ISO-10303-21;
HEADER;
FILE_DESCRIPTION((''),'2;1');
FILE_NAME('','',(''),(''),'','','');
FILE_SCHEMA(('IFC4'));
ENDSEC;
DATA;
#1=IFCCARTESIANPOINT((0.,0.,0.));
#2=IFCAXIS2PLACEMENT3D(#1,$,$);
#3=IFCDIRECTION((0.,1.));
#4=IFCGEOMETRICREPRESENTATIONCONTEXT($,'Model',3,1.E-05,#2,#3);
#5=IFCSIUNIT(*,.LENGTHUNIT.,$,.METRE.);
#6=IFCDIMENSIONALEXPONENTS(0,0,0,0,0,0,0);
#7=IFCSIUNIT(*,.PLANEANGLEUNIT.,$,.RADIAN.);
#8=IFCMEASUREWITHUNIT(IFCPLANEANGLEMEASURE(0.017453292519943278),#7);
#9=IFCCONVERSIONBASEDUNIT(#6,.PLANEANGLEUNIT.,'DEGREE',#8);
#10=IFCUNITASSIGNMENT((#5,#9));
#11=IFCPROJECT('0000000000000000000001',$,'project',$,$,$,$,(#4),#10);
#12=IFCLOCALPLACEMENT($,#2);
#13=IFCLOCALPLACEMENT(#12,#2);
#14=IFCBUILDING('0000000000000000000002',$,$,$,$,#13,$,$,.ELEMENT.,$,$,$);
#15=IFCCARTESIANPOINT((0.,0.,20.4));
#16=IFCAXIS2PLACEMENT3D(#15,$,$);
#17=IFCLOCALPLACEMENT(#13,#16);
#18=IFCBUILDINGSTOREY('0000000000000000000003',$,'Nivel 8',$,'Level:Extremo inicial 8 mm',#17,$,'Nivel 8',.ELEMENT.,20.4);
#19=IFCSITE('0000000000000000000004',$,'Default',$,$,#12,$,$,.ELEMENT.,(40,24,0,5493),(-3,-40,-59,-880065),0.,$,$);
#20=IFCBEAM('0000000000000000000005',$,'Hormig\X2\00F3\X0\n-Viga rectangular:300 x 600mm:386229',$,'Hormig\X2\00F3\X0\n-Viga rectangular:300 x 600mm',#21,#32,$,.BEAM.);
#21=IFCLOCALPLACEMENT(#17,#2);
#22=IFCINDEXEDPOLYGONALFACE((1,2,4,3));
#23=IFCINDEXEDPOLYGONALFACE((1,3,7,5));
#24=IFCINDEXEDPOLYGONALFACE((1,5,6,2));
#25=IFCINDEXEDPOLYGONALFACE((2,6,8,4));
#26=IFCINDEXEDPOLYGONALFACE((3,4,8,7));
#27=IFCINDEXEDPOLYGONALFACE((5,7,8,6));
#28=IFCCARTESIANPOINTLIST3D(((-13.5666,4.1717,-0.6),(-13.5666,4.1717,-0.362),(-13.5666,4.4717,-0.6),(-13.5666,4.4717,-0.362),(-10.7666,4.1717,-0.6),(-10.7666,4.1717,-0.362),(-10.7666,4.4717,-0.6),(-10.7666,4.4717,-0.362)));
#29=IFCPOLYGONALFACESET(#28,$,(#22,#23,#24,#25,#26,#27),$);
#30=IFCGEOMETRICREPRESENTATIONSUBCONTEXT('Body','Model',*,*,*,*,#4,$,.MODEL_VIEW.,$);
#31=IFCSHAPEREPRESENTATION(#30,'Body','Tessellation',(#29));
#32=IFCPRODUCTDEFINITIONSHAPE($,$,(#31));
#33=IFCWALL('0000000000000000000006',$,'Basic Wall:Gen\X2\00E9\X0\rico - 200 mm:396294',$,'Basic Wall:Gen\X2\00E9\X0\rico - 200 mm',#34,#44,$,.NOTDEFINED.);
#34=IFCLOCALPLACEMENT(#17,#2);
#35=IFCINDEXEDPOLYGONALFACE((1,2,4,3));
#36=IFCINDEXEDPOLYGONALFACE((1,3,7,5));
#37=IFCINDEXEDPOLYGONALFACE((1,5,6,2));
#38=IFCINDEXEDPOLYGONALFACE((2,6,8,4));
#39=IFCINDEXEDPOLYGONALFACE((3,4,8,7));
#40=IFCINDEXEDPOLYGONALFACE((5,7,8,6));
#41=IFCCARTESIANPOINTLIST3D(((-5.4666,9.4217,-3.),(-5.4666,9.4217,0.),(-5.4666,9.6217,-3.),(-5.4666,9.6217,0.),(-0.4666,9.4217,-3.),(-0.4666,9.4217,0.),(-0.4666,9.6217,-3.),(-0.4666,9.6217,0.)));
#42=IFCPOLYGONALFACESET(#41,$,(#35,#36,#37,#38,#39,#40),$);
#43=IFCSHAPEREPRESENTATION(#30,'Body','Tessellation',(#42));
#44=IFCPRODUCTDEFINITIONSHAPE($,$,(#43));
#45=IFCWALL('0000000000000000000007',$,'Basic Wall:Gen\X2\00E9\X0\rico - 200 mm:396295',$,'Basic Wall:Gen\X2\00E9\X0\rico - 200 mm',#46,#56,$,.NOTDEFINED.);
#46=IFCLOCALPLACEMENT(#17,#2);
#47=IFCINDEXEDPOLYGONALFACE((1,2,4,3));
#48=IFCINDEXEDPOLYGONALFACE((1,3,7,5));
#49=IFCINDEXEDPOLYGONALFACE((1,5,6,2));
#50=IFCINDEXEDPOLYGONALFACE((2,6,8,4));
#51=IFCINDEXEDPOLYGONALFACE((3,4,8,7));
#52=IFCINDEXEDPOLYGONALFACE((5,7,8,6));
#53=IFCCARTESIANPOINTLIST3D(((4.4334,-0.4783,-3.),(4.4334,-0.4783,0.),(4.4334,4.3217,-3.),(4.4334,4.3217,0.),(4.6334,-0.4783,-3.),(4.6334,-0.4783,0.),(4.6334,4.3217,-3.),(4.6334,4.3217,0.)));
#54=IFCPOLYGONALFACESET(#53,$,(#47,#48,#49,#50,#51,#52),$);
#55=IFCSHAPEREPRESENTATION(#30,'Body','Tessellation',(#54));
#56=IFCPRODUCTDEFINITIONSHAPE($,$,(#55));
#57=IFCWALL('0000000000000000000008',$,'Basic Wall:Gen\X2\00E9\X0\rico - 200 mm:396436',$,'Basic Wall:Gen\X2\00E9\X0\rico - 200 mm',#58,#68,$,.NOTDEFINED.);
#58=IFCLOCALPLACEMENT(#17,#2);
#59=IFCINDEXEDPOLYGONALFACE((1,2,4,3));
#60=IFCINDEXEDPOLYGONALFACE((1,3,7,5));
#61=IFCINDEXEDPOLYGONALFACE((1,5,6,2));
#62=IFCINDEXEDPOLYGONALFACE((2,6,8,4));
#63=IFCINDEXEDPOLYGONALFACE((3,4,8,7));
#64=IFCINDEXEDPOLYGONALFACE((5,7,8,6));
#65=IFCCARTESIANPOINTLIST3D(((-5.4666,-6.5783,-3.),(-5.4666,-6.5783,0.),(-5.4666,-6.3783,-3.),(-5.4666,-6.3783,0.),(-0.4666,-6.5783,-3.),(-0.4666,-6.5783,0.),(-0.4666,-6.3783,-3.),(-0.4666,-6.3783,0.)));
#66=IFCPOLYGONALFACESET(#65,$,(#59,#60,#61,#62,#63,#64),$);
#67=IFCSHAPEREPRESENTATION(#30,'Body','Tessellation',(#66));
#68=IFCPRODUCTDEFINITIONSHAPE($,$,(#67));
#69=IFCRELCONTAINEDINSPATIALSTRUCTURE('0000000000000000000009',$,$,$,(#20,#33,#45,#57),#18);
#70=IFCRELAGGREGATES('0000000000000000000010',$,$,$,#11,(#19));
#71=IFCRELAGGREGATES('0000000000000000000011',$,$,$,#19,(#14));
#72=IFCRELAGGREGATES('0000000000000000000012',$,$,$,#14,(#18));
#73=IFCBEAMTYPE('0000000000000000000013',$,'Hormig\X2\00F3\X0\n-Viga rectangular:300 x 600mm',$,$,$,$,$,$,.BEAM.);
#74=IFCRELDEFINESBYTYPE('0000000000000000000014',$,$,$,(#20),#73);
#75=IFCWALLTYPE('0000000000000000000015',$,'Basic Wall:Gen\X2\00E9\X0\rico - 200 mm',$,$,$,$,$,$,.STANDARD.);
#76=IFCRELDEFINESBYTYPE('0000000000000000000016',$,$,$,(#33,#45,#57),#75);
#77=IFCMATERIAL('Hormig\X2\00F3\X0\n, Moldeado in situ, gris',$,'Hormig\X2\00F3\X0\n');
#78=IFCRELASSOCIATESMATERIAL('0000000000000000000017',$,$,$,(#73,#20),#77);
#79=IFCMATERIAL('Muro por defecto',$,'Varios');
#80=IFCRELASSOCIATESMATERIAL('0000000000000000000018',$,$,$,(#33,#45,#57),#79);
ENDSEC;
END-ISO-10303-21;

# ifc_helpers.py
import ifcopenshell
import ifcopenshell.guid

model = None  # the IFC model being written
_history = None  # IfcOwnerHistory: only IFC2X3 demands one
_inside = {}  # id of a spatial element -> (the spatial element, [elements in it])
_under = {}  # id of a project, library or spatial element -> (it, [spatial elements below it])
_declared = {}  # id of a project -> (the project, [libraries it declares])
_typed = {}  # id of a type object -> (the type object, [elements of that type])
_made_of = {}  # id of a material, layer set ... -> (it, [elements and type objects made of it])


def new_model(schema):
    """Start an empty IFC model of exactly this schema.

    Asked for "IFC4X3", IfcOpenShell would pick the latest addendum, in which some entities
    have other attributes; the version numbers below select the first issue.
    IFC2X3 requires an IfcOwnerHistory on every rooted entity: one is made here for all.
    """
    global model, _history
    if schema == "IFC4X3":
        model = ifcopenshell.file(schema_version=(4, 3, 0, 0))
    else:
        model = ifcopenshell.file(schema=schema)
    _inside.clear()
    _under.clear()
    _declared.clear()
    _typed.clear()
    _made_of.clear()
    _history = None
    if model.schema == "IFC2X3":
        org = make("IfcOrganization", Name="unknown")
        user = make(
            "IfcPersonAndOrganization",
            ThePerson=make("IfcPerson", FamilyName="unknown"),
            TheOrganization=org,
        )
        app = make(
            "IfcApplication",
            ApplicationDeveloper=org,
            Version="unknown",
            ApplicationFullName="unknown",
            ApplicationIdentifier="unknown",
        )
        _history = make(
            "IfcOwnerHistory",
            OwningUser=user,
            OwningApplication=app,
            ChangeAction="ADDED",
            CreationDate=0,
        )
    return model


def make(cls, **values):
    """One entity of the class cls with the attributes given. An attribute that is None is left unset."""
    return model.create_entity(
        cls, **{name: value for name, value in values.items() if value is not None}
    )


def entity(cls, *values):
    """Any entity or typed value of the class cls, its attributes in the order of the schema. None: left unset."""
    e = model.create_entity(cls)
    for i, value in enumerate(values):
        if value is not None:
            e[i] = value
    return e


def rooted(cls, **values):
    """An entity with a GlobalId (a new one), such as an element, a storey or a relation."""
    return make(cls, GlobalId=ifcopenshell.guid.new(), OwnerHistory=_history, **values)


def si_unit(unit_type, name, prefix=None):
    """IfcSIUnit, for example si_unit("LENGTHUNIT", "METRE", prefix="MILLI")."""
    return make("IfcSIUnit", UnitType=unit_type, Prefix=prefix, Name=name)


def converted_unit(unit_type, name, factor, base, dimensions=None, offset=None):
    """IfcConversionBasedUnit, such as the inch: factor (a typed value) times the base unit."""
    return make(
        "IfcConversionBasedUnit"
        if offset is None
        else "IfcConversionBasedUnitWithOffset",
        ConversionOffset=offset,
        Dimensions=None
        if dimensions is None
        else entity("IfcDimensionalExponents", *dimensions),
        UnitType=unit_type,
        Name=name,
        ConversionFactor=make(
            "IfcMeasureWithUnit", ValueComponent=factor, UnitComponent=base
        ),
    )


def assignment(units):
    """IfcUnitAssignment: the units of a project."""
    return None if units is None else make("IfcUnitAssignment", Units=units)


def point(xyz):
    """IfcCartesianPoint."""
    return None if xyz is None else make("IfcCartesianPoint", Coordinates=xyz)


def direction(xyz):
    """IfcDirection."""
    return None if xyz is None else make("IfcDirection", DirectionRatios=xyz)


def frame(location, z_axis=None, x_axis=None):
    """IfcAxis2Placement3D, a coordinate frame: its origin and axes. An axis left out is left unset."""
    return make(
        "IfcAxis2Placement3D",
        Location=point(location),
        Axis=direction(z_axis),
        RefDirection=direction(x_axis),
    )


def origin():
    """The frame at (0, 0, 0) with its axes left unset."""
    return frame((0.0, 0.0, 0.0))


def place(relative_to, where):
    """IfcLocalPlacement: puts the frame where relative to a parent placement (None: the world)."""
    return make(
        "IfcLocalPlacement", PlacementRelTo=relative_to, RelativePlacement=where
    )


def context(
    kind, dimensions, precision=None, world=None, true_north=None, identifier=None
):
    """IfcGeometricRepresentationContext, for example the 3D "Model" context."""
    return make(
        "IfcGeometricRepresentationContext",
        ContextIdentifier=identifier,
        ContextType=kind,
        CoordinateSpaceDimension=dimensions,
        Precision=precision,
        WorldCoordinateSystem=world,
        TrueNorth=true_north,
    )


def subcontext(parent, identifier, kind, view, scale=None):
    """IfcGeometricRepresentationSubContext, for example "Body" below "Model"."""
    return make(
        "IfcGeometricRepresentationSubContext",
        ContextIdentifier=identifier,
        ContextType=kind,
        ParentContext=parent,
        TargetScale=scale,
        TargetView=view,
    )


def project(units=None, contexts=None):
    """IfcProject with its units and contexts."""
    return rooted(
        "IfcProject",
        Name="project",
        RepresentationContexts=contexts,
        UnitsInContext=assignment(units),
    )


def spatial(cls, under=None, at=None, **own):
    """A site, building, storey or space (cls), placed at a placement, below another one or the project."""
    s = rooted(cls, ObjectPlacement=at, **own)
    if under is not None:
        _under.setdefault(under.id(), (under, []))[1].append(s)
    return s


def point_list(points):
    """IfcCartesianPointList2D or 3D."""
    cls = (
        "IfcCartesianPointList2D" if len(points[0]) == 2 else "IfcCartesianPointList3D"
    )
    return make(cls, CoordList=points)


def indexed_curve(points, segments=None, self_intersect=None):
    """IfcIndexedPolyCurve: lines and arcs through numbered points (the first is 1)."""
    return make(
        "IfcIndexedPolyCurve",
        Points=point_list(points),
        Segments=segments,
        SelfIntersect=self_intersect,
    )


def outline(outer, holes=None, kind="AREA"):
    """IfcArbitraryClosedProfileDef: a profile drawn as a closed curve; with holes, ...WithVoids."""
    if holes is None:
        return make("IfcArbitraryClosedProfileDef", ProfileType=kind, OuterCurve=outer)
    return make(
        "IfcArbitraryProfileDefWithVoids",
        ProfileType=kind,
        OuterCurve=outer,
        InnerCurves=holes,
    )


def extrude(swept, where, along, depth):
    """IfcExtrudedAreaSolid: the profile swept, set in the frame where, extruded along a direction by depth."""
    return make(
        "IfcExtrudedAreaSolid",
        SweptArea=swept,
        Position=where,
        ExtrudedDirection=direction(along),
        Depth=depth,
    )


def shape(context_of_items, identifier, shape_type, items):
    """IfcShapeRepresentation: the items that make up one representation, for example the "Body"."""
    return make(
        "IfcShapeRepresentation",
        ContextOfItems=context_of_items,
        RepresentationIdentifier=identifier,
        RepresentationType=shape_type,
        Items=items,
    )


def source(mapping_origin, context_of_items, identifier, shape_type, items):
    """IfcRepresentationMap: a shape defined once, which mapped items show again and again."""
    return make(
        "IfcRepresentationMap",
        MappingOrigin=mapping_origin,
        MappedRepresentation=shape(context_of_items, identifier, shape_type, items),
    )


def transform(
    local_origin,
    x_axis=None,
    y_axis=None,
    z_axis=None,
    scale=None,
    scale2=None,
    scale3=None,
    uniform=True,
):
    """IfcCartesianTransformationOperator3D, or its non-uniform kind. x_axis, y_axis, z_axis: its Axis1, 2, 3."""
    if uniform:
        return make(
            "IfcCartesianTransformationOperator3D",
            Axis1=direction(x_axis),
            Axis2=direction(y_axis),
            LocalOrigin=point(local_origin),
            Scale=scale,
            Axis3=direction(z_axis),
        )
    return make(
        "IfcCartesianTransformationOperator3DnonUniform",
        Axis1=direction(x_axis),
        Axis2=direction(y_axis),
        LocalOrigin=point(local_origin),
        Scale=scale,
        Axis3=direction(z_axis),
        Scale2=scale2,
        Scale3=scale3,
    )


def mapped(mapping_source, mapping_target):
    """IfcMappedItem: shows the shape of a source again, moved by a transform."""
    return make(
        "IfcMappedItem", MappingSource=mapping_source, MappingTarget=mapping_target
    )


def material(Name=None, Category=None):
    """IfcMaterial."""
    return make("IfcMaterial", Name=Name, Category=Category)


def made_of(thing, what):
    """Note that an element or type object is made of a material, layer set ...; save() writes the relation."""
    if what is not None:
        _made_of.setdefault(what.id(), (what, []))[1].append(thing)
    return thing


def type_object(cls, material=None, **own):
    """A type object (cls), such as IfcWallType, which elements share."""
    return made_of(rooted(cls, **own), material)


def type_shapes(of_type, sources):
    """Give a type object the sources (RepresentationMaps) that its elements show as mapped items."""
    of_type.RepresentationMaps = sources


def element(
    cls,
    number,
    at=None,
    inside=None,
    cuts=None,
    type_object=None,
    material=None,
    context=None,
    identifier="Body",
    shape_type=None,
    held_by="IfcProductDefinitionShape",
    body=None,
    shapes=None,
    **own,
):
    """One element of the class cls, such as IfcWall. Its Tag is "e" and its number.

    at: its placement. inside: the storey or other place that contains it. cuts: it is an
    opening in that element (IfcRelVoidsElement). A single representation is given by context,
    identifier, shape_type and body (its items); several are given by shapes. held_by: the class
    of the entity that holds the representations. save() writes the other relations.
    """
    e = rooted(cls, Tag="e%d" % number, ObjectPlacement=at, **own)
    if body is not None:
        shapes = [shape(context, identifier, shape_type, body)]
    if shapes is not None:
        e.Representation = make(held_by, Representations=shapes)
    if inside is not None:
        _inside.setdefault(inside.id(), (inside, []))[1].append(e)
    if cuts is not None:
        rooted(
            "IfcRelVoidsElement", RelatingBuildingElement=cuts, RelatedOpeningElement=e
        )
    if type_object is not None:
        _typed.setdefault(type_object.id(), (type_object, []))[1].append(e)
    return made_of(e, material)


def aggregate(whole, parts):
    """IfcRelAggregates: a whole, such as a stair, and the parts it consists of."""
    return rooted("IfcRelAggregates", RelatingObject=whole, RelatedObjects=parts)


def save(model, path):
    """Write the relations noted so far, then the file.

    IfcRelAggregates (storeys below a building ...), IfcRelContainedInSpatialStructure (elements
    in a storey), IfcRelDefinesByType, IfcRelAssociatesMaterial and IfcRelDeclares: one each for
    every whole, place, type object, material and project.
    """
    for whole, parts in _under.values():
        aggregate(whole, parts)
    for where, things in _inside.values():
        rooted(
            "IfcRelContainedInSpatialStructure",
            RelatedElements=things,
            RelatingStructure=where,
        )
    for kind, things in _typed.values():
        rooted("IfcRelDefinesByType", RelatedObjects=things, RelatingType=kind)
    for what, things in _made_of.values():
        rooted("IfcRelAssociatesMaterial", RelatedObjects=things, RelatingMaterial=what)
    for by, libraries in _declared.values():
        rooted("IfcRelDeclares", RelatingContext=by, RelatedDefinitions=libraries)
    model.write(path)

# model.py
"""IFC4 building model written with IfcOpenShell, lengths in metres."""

from ifc_helpers import new_model, entity, si_unit, converted_unit, direction, frame, origin, place, context, subcontext, project, spatial, indexed_curve, outline, extrude, source, transform, mapped, material, type_object, type_shapes, element, save


model = new_model("IFC4")

# Units and contexts
model_context = context("Model", 3, precision=1e-05, world=origin(), true_north=direction((0.0, 1.0)))
body_context = subcontext(model_context, "Body", "Model", "MODEL_VIEW")
ifc_project = project(units=[si_unit("LENGTHUNIT", "METRE"), converted_unit("PLANEANGLEUNIT", "DEGREE", entity("IfcPlaneAngleMeasure", 0.017453292519943278), si_unit("PLANEANGLEUNIT", "RADIAN"), dimensions=[0, 0, 0, 0, 0, 0, 0])], contexts=[model_context])

# Site, building, storey
site_placement = place(None, origin())
site = spatial("IfcSite", under=ifc_project, at=site_placement, Name="Default", CompositionType="ELEMENT", RefLatitude=(40, 24, 0, 5493), RefLongitude=(-3, -40, -59, -880065), RefElevation=0.0)
building_placement = place(site_placement, origin())
building = spatial("IfcBuilding", under=site, at=building_placement, CompositionType="ELEMENT")
storey_placement = place(building_placement, frame((0.0, 0.0, 20.4)))
storey = spatial("IfcBuildingStorey", under=building, at=storey_placement, Name="Nivel 8", ObjectType="Level:Extremo inicial 8 mm", LongName="Nivel 8", CompositionType="ELEMENT", Elevation=20.4)

# Shared definitions
ifc_material_1 = material(Name="Hormigón, Moldeado in situ, gris", Category="Hormigón")

# Beam
beam_type_1 = type_object("IfcBeamType", Name="Hormigón-Viga rectangular:300 x 600mm", PredefinedType="BEAM", material=ifc_material_1)
shared_shape_1 = source(origin(), body_context, "Body", "SweptSolid", [
    extrude(outline(indexed_curve([(-0.119, -0.15), (0.119, -0.15), (0.119, 0.15), (-0.119, 0.15), (-0.119, -0.15)], self_intersect=False)), frame((-10.7666, 4.3217, 19.919), z_axis=(-1.0, 0.0, 0.0), x_axis=(0.0, 0.0, -1.0)), (0.0, 0.0, 1.0), 2.8),
])
type_shapes(beam_type_1, [shared_shape_1])
beam_1_placement = place(storey_placement, frame((0.0, 0.0, -20.4)))
element("IfcBeam", 1, at=beam_1_placement, inside=storey, type_object=beam_type_1, material=ifc_material_1, Name="Hormigón-Viga rectangular:300 x 600mm:386229", ObjectType="Hormigón-Viga rectangular:300 x 600mm", PredefinedType="BEAM", context=body_context, shape_type="MappedRepresentation", body=[
    mapped(shared_shape_1, transform((0.0, 0.0, 0.0), scale=1.0)),
])

# Walls
ifc_material_2 = material(Name="Muro por defecto", Category="Varios")
wall_type = type_object("IfcWallType", Name="Basic Wall:Genérico - 200 mm", PredefinedType="STANDARD")
wall_1_placement = place(storey_placement, frame((-5.4666, 9.5217, -3.0)))
element("IfcWall", 2, at=wall_1_placement, inside=storey, type_object=wall_type, material=ifc_material_2, Name="Basic Wall:Genérico - 200 mm:396294", ObjectType="Basic Wall:Genérico - 200 mm", PredefinedType="NOTDEFINED", context=body_context, shape_type="SweptSolid", body=[
    extrude(outline(indexed_curve([(5.0, 0.1), (0.0, 0.1), (0.0, -0.1), (5.0, -0.1), (5.0, 0.1)], self_intersect=False)), origin(), (0.0, 0.0, 1.0), 3.0),
])
wall_2_placement = place(storey_placement, frame((4.5334, 4.3217, -3.0), z_axis=(0.0, 0.0, 1.0), x_axis=(0.0, -1.0, 0.0)))
element("IfcWall", 3, at=wall_2_placement, inside=storey, type_object=wall_type, material=ifc_material_2, Name="Basic Wall:Genérico - 200 mm:396295", ObjectType="Basic Wall:Genérico - 200 mm", PredefinedType="NOTDEFINED", context=body_context, shape_type="SweptSolid", body=[
    extrude(outline(indexed_curve([(4.8, 0.1), (0.0, 0.1), (0.0, -0.1), (4.8, -0.1), (4.8, 0.1)], self_intersect=False)), origin(), (0.0, 0.0, 1.0), 3.0),
])
wall_3_placement = place(storey_placement, frame((-5.4666, -6.4783, -3.0)))
element("IfcWall", 4, at=wall_3_placement, inside=storey, type_object=wall_type, material=ifc_material_2, Name="Basic Wall:Genérico - 200 mm:396436", ObjectType="Basic Wall:Genérico - 200 mm", PredefinedType="NOTDEFINED", context=body_context, shape_type="SweptSolid", body=[
    extrude(outline(indexed_curve([(5.0, 0.1), (0.0, 0.1), (0.0, -0.1), (5.0, -0.1), (5.0, 0.1)], self_intersect=False)), origin(), (0.0, 0.0, 1.0), 3.0),
])

save(model, "model.ifc")
